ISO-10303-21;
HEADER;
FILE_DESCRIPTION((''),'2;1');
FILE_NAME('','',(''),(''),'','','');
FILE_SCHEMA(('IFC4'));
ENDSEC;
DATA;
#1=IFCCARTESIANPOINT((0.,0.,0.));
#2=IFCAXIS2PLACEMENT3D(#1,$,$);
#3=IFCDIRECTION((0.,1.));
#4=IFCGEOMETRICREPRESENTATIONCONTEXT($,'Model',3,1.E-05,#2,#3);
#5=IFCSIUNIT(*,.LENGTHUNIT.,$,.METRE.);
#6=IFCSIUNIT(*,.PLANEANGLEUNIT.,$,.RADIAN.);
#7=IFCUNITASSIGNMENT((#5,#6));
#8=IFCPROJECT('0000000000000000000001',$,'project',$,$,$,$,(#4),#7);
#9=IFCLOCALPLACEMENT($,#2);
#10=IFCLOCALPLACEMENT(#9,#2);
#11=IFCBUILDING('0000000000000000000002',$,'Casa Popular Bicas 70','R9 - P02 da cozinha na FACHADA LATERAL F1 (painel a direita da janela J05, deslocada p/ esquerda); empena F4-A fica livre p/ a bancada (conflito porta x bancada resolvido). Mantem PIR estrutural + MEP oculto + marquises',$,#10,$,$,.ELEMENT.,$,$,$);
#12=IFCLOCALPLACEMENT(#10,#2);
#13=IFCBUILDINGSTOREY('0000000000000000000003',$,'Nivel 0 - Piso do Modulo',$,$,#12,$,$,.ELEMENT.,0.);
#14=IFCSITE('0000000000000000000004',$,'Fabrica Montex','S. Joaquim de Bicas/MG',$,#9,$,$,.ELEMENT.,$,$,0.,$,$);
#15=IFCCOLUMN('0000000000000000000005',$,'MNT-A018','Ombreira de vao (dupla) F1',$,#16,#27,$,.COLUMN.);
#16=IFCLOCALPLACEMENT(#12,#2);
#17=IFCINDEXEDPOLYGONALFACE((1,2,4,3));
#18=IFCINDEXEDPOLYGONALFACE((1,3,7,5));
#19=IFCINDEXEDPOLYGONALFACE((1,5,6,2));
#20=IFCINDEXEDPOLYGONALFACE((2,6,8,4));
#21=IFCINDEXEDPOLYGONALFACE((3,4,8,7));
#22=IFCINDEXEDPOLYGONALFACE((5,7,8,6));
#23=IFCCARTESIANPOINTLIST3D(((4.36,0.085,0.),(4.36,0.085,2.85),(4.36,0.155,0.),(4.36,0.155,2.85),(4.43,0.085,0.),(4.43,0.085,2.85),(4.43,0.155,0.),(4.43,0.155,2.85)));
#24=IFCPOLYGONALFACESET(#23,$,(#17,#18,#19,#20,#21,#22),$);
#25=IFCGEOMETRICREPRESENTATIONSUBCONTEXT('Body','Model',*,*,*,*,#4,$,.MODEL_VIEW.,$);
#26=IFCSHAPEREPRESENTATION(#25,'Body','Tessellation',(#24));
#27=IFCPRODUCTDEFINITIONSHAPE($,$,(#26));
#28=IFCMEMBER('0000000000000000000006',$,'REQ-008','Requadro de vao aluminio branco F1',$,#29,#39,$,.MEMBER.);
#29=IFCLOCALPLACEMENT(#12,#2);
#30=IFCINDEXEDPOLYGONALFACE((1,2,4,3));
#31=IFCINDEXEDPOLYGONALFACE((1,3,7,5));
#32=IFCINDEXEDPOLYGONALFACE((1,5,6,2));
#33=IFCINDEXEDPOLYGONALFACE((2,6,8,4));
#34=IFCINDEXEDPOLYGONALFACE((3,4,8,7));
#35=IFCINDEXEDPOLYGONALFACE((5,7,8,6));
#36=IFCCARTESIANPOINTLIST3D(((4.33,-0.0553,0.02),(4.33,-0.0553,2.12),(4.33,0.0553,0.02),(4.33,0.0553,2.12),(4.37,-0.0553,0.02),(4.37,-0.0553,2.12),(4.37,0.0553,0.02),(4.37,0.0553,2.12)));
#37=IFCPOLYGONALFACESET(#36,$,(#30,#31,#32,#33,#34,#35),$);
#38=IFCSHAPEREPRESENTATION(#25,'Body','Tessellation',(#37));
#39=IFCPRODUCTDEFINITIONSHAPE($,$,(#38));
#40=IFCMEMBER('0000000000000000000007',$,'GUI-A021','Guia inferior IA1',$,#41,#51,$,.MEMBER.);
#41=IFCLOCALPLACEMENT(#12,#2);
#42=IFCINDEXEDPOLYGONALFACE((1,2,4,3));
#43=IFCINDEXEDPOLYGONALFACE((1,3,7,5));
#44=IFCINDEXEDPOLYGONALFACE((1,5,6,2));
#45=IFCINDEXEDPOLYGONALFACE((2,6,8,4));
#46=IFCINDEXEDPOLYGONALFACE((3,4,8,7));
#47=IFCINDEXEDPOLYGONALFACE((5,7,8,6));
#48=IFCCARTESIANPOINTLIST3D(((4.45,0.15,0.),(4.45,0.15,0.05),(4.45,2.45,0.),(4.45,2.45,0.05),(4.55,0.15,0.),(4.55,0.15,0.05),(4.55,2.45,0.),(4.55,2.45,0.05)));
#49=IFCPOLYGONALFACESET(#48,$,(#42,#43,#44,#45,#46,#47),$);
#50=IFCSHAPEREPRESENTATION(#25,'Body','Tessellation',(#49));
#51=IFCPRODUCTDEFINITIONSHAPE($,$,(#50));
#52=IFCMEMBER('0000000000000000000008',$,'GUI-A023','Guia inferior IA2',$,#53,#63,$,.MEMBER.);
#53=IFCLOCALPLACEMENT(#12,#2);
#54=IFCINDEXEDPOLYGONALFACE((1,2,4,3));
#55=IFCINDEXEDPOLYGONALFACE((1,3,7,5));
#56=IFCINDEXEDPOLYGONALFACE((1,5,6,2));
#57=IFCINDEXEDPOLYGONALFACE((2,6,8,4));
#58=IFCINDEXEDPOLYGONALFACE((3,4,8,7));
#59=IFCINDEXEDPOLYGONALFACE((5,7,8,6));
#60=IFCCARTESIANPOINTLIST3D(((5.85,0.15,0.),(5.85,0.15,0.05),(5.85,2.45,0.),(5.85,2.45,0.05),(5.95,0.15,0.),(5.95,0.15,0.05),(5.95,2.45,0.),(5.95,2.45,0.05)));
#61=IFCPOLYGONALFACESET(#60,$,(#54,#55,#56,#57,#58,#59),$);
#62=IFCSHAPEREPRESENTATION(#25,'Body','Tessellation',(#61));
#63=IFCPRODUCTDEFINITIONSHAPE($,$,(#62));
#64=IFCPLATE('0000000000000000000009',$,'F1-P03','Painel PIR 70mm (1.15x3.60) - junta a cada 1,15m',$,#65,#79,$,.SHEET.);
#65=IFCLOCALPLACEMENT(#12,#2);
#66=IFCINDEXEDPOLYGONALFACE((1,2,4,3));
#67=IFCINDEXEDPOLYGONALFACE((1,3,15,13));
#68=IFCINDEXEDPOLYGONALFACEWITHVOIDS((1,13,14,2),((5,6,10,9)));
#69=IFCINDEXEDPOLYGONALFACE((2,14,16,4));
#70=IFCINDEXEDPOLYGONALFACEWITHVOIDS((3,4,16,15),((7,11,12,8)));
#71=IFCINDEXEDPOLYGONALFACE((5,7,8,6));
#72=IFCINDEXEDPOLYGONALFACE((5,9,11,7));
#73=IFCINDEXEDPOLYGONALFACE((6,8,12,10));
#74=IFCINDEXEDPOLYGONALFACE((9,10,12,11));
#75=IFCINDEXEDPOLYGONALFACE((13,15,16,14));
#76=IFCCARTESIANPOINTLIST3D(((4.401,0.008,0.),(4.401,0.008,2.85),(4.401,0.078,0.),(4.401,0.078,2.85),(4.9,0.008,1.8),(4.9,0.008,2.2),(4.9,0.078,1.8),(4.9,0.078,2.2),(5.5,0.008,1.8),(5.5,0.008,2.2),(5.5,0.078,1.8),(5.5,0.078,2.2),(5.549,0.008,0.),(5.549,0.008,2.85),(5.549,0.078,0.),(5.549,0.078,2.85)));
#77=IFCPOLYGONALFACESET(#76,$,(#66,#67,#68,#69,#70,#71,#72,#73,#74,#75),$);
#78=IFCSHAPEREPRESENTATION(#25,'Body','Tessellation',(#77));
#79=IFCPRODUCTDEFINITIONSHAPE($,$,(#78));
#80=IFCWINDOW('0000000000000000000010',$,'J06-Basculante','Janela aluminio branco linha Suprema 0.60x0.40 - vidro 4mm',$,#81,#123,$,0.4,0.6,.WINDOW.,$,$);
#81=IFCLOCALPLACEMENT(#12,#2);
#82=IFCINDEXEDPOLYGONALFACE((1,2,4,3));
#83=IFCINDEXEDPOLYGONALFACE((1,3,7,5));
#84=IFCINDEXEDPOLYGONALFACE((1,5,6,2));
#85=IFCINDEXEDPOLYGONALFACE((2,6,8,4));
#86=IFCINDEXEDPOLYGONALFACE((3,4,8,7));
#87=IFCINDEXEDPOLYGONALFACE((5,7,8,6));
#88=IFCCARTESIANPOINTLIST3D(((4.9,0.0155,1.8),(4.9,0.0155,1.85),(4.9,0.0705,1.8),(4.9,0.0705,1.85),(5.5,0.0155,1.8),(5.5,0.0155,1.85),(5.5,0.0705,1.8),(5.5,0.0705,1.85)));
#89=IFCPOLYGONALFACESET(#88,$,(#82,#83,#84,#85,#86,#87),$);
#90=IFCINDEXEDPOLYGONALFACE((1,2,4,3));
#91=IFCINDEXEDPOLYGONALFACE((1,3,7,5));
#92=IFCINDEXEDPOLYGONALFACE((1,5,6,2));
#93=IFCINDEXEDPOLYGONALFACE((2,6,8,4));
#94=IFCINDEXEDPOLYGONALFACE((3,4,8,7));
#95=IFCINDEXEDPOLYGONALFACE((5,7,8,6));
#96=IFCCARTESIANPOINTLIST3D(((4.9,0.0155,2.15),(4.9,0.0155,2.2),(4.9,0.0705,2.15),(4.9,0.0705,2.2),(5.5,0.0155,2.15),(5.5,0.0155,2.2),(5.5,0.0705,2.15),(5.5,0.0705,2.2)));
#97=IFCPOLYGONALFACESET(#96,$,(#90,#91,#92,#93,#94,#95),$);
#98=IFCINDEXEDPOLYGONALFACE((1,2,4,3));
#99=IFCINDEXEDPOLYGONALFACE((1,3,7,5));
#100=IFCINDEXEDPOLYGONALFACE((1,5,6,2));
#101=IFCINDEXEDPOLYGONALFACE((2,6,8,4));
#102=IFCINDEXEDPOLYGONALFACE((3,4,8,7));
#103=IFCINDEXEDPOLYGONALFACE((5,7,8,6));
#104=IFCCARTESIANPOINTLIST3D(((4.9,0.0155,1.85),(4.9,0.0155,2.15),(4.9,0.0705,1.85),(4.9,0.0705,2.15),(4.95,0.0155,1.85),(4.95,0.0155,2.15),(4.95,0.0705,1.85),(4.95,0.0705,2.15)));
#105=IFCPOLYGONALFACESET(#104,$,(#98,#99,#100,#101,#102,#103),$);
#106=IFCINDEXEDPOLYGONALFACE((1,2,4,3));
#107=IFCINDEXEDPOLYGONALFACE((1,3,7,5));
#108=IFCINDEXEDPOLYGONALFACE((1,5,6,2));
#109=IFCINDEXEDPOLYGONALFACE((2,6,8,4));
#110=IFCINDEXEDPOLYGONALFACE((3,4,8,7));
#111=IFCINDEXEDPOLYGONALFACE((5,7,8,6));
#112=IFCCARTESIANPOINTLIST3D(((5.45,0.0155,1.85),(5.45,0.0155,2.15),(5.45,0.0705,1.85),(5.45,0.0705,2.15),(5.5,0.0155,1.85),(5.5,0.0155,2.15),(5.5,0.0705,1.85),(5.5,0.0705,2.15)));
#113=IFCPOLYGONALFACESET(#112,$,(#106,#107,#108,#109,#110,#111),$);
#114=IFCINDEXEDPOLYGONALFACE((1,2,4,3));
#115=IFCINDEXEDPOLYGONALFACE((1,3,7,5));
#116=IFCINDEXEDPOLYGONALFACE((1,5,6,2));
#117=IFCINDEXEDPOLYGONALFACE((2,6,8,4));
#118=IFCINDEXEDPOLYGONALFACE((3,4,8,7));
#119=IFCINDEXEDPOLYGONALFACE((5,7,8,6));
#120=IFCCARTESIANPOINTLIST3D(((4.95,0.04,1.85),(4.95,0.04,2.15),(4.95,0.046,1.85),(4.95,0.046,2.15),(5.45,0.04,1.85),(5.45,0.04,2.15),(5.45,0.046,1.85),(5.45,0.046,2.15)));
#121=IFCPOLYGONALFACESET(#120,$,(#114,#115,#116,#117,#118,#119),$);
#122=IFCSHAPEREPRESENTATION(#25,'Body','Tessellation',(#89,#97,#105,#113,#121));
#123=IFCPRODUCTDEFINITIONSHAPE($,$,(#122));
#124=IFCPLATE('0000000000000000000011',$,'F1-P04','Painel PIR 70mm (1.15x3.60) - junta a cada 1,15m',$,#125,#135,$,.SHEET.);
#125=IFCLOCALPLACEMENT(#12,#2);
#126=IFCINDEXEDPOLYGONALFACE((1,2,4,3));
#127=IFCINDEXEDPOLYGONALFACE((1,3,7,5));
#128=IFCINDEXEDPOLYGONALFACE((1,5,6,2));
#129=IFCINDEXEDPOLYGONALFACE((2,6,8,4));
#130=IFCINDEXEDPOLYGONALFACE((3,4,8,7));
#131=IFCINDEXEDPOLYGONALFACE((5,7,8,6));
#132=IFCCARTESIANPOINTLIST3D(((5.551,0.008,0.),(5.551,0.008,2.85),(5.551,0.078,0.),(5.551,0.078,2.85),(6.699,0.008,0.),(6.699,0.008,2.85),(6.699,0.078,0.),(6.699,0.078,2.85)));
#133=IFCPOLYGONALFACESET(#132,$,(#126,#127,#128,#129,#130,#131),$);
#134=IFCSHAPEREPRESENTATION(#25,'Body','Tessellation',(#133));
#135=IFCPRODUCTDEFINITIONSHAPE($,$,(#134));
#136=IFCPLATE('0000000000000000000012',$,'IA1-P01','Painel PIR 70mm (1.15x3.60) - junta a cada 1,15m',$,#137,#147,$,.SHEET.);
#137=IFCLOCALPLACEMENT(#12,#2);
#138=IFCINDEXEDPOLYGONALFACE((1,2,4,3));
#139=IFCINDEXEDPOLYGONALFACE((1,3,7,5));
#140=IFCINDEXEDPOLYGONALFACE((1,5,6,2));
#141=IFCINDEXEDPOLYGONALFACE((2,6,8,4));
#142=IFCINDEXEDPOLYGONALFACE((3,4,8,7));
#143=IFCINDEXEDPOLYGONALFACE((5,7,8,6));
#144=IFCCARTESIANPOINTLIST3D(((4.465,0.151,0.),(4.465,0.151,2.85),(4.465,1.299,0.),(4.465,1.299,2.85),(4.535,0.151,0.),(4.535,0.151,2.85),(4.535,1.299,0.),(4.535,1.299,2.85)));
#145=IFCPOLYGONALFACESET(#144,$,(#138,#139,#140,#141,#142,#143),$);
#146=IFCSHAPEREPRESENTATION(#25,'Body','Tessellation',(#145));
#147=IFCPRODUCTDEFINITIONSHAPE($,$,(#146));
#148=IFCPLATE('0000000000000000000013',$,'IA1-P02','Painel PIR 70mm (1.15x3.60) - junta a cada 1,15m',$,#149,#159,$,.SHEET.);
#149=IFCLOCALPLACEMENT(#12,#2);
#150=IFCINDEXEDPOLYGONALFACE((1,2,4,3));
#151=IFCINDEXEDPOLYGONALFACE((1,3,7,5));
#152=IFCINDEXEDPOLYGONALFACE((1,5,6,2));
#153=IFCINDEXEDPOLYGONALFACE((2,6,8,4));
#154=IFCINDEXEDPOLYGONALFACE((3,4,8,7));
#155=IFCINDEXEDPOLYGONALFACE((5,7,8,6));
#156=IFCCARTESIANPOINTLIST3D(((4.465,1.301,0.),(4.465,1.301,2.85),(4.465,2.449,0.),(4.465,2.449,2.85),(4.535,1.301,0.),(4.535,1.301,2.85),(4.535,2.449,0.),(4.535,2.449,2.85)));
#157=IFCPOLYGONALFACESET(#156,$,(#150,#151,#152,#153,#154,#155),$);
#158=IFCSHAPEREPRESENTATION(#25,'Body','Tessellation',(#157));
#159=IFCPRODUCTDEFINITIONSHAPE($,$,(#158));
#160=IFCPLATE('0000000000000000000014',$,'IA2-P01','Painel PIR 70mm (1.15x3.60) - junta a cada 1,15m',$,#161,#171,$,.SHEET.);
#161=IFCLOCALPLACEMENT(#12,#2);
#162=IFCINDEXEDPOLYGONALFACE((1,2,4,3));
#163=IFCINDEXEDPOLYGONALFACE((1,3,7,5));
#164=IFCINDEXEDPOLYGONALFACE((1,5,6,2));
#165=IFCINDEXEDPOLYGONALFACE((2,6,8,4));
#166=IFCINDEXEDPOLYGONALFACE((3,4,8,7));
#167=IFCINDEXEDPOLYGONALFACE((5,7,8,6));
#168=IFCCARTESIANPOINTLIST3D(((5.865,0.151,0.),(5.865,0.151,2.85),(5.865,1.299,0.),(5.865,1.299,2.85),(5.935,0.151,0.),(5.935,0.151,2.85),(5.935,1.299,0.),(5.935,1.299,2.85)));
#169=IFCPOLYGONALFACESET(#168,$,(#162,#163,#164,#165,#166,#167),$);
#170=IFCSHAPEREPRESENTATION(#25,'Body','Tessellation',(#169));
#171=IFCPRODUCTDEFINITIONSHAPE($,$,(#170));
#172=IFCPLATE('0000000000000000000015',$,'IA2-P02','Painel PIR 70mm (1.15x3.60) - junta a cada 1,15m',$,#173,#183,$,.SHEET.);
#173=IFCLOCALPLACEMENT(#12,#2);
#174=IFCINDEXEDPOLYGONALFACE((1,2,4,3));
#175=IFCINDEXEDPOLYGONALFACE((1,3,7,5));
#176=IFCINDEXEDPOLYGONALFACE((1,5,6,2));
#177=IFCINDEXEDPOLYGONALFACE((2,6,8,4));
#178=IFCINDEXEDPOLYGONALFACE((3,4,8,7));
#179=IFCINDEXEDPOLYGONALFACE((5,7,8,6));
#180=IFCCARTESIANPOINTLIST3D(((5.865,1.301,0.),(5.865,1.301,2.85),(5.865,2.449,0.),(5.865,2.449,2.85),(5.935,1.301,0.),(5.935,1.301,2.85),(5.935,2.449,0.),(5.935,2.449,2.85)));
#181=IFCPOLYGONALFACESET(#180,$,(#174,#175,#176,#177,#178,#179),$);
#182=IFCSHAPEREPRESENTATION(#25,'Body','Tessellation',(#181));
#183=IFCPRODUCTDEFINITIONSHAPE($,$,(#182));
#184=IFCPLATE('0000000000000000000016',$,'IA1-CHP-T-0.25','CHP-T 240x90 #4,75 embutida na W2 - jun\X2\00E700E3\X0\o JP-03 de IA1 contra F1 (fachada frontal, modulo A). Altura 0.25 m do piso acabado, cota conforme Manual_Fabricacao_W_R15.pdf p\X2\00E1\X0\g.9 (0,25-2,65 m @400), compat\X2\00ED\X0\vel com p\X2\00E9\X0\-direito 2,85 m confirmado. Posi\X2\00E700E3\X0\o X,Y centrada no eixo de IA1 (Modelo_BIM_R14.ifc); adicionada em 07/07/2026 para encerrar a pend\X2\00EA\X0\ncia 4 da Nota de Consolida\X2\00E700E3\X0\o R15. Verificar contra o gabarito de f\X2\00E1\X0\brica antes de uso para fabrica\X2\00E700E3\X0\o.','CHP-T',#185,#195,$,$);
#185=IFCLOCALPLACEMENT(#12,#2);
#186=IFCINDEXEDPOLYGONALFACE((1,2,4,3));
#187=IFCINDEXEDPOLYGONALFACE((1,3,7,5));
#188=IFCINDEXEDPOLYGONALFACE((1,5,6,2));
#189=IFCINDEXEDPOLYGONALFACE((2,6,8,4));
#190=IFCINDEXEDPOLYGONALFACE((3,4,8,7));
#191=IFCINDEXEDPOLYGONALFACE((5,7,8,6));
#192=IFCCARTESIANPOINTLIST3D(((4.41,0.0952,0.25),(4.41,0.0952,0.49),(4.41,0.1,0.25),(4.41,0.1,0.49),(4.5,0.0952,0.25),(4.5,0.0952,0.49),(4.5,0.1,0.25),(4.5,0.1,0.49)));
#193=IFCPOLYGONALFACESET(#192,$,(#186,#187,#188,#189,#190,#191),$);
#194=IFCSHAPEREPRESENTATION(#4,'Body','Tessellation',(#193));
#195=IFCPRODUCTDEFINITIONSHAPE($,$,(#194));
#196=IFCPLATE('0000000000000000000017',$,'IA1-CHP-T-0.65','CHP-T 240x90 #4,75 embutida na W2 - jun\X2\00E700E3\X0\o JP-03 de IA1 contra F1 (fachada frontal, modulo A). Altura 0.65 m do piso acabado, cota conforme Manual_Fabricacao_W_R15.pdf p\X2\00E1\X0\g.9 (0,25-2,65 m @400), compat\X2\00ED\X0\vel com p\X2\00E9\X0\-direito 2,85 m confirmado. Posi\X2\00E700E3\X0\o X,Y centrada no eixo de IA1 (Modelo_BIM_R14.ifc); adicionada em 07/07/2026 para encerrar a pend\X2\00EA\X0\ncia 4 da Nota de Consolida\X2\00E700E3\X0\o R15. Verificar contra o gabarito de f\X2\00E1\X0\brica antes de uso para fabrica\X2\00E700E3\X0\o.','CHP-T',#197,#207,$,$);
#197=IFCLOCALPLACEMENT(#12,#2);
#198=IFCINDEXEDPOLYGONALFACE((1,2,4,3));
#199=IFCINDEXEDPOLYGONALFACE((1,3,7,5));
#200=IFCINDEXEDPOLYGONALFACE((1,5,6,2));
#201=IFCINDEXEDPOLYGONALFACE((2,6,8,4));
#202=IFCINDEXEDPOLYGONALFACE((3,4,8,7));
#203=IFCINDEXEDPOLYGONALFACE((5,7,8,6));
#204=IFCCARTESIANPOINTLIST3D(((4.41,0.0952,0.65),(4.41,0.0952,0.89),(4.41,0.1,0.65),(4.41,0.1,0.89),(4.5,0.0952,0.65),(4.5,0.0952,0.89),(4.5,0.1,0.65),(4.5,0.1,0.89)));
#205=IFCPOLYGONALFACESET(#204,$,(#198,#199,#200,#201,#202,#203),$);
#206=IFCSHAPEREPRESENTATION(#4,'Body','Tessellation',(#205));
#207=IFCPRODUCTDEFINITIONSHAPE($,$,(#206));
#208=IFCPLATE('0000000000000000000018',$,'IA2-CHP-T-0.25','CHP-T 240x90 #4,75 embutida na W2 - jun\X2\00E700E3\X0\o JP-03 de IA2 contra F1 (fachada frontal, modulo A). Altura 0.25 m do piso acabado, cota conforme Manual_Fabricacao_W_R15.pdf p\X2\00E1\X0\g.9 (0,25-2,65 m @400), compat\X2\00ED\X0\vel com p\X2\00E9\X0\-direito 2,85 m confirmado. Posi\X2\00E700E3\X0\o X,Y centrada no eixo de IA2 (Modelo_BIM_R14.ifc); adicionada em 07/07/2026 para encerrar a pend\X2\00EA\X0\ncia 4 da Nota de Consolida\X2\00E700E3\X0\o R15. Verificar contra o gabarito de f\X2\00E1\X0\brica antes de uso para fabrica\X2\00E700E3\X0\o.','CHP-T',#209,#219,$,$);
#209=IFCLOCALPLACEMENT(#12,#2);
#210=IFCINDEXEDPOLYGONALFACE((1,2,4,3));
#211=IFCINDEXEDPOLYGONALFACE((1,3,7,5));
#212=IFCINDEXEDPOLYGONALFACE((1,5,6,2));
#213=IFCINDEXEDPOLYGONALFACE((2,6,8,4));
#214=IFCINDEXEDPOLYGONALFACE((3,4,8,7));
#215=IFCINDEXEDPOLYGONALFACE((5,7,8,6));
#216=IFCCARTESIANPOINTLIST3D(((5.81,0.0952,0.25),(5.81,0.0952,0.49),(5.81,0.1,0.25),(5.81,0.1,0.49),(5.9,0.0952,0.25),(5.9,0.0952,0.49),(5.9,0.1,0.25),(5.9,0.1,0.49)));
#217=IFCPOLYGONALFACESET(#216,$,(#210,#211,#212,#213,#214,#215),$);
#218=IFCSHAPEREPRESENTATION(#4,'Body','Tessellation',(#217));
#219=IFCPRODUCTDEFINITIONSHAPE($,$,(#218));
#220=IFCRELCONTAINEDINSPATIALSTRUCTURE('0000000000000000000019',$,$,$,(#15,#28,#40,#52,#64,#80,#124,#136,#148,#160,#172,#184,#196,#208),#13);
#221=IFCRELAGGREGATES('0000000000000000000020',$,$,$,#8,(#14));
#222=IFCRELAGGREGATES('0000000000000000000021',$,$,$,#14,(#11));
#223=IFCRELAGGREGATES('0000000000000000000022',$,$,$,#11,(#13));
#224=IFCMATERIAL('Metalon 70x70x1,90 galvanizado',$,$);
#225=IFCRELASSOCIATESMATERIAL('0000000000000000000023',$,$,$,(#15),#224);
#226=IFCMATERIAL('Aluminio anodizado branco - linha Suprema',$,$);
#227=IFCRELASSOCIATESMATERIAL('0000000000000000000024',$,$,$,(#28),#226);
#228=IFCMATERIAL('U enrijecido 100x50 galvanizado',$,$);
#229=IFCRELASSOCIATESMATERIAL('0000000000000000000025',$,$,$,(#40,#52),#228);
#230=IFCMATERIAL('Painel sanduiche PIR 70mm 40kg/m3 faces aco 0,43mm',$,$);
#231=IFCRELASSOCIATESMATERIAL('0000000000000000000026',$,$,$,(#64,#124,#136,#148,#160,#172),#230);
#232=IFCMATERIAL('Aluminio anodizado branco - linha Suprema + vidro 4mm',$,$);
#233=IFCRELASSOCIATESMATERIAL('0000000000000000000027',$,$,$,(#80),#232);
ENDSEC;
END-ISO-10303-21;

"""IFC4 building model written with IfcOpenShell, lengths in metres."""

from ifc_helpers import new_model, si_unit, direction, frame, frame_2d, origin, origin_with_axes, origin_2d, place, context, subcontext, project, spatial, rectangle, extrude, material, element, fill, save


model = new_model("IFC4")

# Units and contexts
model_context = context("Model", 3, precision=1e-05, world=origin(), true_north=direction((0.0, 1.0)))
body_context = subcontext(model_context, "Body", "Model", "MODEL_VIEW")
ifc_project = project(units=[si_unit("LENGTHUNIT", "METRE"), si_unit("PLANEANGLEUNIT", "RADIAN")], contexts=[model_context])

# Site, building, storey
site_placement = place(None, origin())
site = spatial("IfcSite", under=ifc_project, at=site_placement, Name="Fabrica Montex", Description="S. Joaquim de Bicas/MG", CompositionType="ELEMENT", RefElevation=0.0)
building_placement = place(site_placement, origin())
building = spatial("IfcBuilding", under=site, at=building_placement, Name="Casa Popular Bicas 70", Description="R9 - P02 da cozinha na FACHADA LATERAL F1 (painel a direita da janela J05, deslocada p/ esquerda); empena F4-A fica livre p/ a bancada (conflito porta x bancada resolvido). Mantem PIR estrutural + MEP oculto + marquises", CompositionType="ELEMENT")
storey_placement = place(building_placement, origin())
storey = spatial("IfcBuildingStorey", under=building, at=storey_placement, Name="Nivel 0 - Piso do Modulo", CompositionType="ELEMENT", Elevation=0.0)

# Column
ifc_material_1 = material(Name="Metalon 70x70x1,90 galvanizado")
column_placement = place(storey_placement, frame((4.395, 0.12, 0.0)))
element("IfcColumn", 1, at=column_placement, inside=storey, material=ifc_material_1, Name="MNT-A018", Description="Ombreira de vao (dupla) F1", PredefinedType="COLUMN", context=body_context, shape_type="SweptSolid", body=[
    extrude(rectangle(XDim=0.07, YDim=0.07, at=origin_2d()), origin(), (0.0, 0.0, 1.0), 2.85),
])

# Members
ifc_material_2 = material(Name="Aluminio anodizado branco - linha Suprema")
member_placement = place(storey_placement, frame((4.35, 0.0, 0.02), z_axis=(0.0, 0.0, 1.0), x_axis=(1.0, 0.0, 0.0)))
element("IfcMember", 2, at=member_placement, inside=storey, material=ifc_material_2, Name="REQ-008", Description="Requadro de vao aluminio branco F1", PredefinedType="MEMBER", context=body_context, shape_type="SweptSolid", body=[
    extrude(rectangle(XDim=0.04, YDim=0.1105, at=origin_2d()), origin(), (0.0, 0.0, 1.0), 2.1),
])
ifc_material_3 = material(Name="U enrijecido 100x50 galvanizado")
for number, where, z_axis, x_axis, name, description in (
    (3, (4.5, 0.15, 0.025), (0.0, 1.0, 0.0), (0.0, 0.0, 1.0), "GUI-A021", "Guia inferior IA1"),
    (4, (5.9, 0.15, 0.025), (0.0, 1.0, 0.0), (0.0, 0.0, 1.0), "GUI-A023", "Guia inferior IA2"),
):
    element("IfcMember", number, at=place(storey_placement, frame(where, z_axis=z_axis, x_axis=x_axis)), inside=storey, material=ifc_material_3, Name=name, Description=description, PredefinedType="MEMBER", context=body_context, shape_type="SweptSolid", body=[
        extrude(rectangle(XDim=0.05, YDim=0.1, at=origin_2d()), origin(), (0.0, 0.0, 1.0), 2.3),
    ])

# Plate, opening, window
ifc_material_4 = material(Name="Painel sanduiche PIR 70mm 40kg/m3 faces aco 0,43mm")
plate_placement = place(storey_placement, frame((4.401, 0.043, 0.0), x_axis=(1.0, 0.0, 0.0)))
plate = element("IfcPlate", 5, at=plate_placement, inside=storey, material=ifc_material_4, Name="F1-P03", Description="Painel PIR 70mm (1.15x3.60) - junta a cada 1,15m", PredefinedType="SHEET", context=body_context, shape_type="SweptSolid", body=[
    extrude(rectangle(XDim=1.148, YDim=0.07, at=frame_2d((0.574, 0.0))), origin(), (0.0, 0.0, 1.0), 2.85),
])
opening_1_placement = place(storey_placement, frame((5.2, 0.043, 1.8)))
opening_1 = element("IfcOpeningElement", 6, at=opening_1_placement, cuts=plate, PredefinedType="OPENING", context=body_context, shape_type="SweptSolid", body=[
    extrude(rectangle(XDim=0.6, YDim=0.1, at=origin_2d()), origin(), (0.0, 0.0, 1.0), 0.4),
])
ifc_material_5 = material(Name="Aluminio anodizado branco - linha Suprema + vidro 4mm")
window_placement = place(storey_placement, frame((4.9, 0.043, 1.8), x_axis=(1.0, 0.0, 0.0)))
window = element("IfcWindow", 7, at=window_placement, inside=storey, material=ifc_material_5, Name="J06-Basculante", Description="Janela aluminio branco linha Suprema 0.60x0.40 - vidro 4mm", OverallHeight=0.4, OverallWidth=0.6, PredefinedType="WINDOW", context=body_context, shape_type="SweptSolid", body=[
    extrude(rectangle(XDim=0.6, YDim=0.055, at=frame_2d((0.3, 0.0))), origin(), (0.0, 0.0, 1.0), 0.05),
    extrude(rectangle(XDim=0.6, YDim=0.055, at=frame_2d((0.3, 0.0))), frame((0.0, 0.0, 0.35)), (0.0, 0.0, 1.0), 0.05),
    extrude(rectangle(XDim=0.05, YDim=0.055, at=frame_2d((0.025, 0.0))), frame((0.0, 0.0, 0.05)), (0.0, 0.0, 1.0), 0.3),
    extrude(rectangle(XDim=0.05, YDim=0.055, at=frame_2d((0.575, 0.0))), frame((0.0, 0.0, 0.05)), (0.0, 0.0, 1.0), 0.3),
    extrude(rectangle(XDim=0.5, YDim=0.006, at=frame_2d((0.3, 0.0))), frame((0.0, 0.0, 0.05)), (0.0, 0.0, 1.0), 0.3),
])
fill(opening_1, window)

# Plates
for number, where, x_axis, name in (
    (8, (5.551, 0.043, 0.0), (1.0, 0.0, 0.0), "F1-P04"),
    (9, (4.5, 0.151, 0.0), (0.0, 1.0, 0.0), "IA1-P01"),
    (10, (4.5, 1.301, 0.0), (0.0, 1.0, 0.0), "IA1-P02"),
    (11, (5.9, 0.151, 0.0), (0.0, 1.0, 0.0), "IA2-P01"),
    (12, (5.9, 1.301, 0.0), (0.0, 1.0, 0.0), "IA2-P02"),
):
    element("IfcPlate", number, at=place(storey_placement, frame(where, x_axis=x_axis)), inside=storey, material=ifc_material_4, Name=name, Description="Painel PIR 70mm (1.15x3.60) - junta a cada 1,15m", PredefinedType="SHEET", context=body_context, shape_type="SweptSolid", body=[
        extrude(rectangle(XDim=1.148, YDim=0.07, at=frame_2d((0.574, 0.0))), origin(), (0.0, 0.0, 1.0), 2.85),
    ])
for number, where, z_axis, x_axis, name, description in (
    (13, (4.455, 0.0976, 0.25), (0.0, 0.0, 1.0), (1.0, 0.0, 0.0), "IA1-CHP-T-0.25", "CHP-T 240x90 #4,75 embutida na W2 - junção JP-03 de IA1 contra F1 (fachada frontal, modulo A). Altura 0.25 m do piso acabado, cota conforme Manual_Fabricacao_W_R15.pdf pág.9 (0,25-2,65 m @400), compatível com pé-direito 2,85 m confirmado. Posição X,Y centrada no eixo de IA1 (Modelo_BIM_R14.ifc); adicionada em 07/07/2026 para encerrar a pendência 4 da Nota de Consolidação R15. Verificar contra o gabarito de fábrica antes de uso para fabricação."),
    (14, (4.455, 0.0976, 0.65), (0.0, 0.0, 1.0), (1.0, 0.0, 0.0), "IA1-CHP-T-0.65", "CHP-T 240x90 #4,75 embutida na W2 - junção JP-03 de IA1 contra F1 (fachada frontal, modulo A). Altura 0.65 m do piso acabado, cota conforme Manual_Fabricacao_W_R15.pdf pág.9 (0,25-2,65 m @400), compatível com pé-direito 2,85 m confirmado. Posição X,Y centrada no eixo de IA1 (Modelo_BIM_R14.ifc); adicionada em 07/07/2026 para encerrar a pendência 4 da Nota de Consolidação R15. Verificar contra o gabarito de fábrica antes de uso para fabricação."),
    (15, (5.855, 0.0976, 0.25), (0.0, 0.0, 1.0), (1.0, 0.0, 0.0), "IA2-CHP-T-0.25", "CHP-T 240x90 #4,75 embutida na W2 - junção JP-03 de IA2 contra F1 (fachada frontal, modulo A). Altura 0.25 m do piso acabado, cota conforme Manual_Fabricacao_W_R15.pdf pág.9 (0,25-2,65 m @400), compatível com pé-direito 2,85 m confirmado. Posição X,Y centrada no eixo de IA2 (Modelo_BIM_R14.ifc); adicionada em 07/07/2026 para encerrar a pendência 4 da Nota de Consolidação R15. Verificar contra o gabarito de fábrica antes de uso para fabricação."),
):
    element("IfcPlate", number, at=place(storey_placement, frame(where, z_axis=z_axis, x_axis=x_axis)), inside=storey, Name=name, Description=description, ObjectType="CHP-T", context=model_context, shape_type="SweptSolid", body=[
        extrude(rectangle(XDim=0.09, YDim=0.0047, at=origin_2d()), origin_with_axes(), (0.0, 0.0, 1.0), 0.24),
    ])

save(model, "model.ifc")
